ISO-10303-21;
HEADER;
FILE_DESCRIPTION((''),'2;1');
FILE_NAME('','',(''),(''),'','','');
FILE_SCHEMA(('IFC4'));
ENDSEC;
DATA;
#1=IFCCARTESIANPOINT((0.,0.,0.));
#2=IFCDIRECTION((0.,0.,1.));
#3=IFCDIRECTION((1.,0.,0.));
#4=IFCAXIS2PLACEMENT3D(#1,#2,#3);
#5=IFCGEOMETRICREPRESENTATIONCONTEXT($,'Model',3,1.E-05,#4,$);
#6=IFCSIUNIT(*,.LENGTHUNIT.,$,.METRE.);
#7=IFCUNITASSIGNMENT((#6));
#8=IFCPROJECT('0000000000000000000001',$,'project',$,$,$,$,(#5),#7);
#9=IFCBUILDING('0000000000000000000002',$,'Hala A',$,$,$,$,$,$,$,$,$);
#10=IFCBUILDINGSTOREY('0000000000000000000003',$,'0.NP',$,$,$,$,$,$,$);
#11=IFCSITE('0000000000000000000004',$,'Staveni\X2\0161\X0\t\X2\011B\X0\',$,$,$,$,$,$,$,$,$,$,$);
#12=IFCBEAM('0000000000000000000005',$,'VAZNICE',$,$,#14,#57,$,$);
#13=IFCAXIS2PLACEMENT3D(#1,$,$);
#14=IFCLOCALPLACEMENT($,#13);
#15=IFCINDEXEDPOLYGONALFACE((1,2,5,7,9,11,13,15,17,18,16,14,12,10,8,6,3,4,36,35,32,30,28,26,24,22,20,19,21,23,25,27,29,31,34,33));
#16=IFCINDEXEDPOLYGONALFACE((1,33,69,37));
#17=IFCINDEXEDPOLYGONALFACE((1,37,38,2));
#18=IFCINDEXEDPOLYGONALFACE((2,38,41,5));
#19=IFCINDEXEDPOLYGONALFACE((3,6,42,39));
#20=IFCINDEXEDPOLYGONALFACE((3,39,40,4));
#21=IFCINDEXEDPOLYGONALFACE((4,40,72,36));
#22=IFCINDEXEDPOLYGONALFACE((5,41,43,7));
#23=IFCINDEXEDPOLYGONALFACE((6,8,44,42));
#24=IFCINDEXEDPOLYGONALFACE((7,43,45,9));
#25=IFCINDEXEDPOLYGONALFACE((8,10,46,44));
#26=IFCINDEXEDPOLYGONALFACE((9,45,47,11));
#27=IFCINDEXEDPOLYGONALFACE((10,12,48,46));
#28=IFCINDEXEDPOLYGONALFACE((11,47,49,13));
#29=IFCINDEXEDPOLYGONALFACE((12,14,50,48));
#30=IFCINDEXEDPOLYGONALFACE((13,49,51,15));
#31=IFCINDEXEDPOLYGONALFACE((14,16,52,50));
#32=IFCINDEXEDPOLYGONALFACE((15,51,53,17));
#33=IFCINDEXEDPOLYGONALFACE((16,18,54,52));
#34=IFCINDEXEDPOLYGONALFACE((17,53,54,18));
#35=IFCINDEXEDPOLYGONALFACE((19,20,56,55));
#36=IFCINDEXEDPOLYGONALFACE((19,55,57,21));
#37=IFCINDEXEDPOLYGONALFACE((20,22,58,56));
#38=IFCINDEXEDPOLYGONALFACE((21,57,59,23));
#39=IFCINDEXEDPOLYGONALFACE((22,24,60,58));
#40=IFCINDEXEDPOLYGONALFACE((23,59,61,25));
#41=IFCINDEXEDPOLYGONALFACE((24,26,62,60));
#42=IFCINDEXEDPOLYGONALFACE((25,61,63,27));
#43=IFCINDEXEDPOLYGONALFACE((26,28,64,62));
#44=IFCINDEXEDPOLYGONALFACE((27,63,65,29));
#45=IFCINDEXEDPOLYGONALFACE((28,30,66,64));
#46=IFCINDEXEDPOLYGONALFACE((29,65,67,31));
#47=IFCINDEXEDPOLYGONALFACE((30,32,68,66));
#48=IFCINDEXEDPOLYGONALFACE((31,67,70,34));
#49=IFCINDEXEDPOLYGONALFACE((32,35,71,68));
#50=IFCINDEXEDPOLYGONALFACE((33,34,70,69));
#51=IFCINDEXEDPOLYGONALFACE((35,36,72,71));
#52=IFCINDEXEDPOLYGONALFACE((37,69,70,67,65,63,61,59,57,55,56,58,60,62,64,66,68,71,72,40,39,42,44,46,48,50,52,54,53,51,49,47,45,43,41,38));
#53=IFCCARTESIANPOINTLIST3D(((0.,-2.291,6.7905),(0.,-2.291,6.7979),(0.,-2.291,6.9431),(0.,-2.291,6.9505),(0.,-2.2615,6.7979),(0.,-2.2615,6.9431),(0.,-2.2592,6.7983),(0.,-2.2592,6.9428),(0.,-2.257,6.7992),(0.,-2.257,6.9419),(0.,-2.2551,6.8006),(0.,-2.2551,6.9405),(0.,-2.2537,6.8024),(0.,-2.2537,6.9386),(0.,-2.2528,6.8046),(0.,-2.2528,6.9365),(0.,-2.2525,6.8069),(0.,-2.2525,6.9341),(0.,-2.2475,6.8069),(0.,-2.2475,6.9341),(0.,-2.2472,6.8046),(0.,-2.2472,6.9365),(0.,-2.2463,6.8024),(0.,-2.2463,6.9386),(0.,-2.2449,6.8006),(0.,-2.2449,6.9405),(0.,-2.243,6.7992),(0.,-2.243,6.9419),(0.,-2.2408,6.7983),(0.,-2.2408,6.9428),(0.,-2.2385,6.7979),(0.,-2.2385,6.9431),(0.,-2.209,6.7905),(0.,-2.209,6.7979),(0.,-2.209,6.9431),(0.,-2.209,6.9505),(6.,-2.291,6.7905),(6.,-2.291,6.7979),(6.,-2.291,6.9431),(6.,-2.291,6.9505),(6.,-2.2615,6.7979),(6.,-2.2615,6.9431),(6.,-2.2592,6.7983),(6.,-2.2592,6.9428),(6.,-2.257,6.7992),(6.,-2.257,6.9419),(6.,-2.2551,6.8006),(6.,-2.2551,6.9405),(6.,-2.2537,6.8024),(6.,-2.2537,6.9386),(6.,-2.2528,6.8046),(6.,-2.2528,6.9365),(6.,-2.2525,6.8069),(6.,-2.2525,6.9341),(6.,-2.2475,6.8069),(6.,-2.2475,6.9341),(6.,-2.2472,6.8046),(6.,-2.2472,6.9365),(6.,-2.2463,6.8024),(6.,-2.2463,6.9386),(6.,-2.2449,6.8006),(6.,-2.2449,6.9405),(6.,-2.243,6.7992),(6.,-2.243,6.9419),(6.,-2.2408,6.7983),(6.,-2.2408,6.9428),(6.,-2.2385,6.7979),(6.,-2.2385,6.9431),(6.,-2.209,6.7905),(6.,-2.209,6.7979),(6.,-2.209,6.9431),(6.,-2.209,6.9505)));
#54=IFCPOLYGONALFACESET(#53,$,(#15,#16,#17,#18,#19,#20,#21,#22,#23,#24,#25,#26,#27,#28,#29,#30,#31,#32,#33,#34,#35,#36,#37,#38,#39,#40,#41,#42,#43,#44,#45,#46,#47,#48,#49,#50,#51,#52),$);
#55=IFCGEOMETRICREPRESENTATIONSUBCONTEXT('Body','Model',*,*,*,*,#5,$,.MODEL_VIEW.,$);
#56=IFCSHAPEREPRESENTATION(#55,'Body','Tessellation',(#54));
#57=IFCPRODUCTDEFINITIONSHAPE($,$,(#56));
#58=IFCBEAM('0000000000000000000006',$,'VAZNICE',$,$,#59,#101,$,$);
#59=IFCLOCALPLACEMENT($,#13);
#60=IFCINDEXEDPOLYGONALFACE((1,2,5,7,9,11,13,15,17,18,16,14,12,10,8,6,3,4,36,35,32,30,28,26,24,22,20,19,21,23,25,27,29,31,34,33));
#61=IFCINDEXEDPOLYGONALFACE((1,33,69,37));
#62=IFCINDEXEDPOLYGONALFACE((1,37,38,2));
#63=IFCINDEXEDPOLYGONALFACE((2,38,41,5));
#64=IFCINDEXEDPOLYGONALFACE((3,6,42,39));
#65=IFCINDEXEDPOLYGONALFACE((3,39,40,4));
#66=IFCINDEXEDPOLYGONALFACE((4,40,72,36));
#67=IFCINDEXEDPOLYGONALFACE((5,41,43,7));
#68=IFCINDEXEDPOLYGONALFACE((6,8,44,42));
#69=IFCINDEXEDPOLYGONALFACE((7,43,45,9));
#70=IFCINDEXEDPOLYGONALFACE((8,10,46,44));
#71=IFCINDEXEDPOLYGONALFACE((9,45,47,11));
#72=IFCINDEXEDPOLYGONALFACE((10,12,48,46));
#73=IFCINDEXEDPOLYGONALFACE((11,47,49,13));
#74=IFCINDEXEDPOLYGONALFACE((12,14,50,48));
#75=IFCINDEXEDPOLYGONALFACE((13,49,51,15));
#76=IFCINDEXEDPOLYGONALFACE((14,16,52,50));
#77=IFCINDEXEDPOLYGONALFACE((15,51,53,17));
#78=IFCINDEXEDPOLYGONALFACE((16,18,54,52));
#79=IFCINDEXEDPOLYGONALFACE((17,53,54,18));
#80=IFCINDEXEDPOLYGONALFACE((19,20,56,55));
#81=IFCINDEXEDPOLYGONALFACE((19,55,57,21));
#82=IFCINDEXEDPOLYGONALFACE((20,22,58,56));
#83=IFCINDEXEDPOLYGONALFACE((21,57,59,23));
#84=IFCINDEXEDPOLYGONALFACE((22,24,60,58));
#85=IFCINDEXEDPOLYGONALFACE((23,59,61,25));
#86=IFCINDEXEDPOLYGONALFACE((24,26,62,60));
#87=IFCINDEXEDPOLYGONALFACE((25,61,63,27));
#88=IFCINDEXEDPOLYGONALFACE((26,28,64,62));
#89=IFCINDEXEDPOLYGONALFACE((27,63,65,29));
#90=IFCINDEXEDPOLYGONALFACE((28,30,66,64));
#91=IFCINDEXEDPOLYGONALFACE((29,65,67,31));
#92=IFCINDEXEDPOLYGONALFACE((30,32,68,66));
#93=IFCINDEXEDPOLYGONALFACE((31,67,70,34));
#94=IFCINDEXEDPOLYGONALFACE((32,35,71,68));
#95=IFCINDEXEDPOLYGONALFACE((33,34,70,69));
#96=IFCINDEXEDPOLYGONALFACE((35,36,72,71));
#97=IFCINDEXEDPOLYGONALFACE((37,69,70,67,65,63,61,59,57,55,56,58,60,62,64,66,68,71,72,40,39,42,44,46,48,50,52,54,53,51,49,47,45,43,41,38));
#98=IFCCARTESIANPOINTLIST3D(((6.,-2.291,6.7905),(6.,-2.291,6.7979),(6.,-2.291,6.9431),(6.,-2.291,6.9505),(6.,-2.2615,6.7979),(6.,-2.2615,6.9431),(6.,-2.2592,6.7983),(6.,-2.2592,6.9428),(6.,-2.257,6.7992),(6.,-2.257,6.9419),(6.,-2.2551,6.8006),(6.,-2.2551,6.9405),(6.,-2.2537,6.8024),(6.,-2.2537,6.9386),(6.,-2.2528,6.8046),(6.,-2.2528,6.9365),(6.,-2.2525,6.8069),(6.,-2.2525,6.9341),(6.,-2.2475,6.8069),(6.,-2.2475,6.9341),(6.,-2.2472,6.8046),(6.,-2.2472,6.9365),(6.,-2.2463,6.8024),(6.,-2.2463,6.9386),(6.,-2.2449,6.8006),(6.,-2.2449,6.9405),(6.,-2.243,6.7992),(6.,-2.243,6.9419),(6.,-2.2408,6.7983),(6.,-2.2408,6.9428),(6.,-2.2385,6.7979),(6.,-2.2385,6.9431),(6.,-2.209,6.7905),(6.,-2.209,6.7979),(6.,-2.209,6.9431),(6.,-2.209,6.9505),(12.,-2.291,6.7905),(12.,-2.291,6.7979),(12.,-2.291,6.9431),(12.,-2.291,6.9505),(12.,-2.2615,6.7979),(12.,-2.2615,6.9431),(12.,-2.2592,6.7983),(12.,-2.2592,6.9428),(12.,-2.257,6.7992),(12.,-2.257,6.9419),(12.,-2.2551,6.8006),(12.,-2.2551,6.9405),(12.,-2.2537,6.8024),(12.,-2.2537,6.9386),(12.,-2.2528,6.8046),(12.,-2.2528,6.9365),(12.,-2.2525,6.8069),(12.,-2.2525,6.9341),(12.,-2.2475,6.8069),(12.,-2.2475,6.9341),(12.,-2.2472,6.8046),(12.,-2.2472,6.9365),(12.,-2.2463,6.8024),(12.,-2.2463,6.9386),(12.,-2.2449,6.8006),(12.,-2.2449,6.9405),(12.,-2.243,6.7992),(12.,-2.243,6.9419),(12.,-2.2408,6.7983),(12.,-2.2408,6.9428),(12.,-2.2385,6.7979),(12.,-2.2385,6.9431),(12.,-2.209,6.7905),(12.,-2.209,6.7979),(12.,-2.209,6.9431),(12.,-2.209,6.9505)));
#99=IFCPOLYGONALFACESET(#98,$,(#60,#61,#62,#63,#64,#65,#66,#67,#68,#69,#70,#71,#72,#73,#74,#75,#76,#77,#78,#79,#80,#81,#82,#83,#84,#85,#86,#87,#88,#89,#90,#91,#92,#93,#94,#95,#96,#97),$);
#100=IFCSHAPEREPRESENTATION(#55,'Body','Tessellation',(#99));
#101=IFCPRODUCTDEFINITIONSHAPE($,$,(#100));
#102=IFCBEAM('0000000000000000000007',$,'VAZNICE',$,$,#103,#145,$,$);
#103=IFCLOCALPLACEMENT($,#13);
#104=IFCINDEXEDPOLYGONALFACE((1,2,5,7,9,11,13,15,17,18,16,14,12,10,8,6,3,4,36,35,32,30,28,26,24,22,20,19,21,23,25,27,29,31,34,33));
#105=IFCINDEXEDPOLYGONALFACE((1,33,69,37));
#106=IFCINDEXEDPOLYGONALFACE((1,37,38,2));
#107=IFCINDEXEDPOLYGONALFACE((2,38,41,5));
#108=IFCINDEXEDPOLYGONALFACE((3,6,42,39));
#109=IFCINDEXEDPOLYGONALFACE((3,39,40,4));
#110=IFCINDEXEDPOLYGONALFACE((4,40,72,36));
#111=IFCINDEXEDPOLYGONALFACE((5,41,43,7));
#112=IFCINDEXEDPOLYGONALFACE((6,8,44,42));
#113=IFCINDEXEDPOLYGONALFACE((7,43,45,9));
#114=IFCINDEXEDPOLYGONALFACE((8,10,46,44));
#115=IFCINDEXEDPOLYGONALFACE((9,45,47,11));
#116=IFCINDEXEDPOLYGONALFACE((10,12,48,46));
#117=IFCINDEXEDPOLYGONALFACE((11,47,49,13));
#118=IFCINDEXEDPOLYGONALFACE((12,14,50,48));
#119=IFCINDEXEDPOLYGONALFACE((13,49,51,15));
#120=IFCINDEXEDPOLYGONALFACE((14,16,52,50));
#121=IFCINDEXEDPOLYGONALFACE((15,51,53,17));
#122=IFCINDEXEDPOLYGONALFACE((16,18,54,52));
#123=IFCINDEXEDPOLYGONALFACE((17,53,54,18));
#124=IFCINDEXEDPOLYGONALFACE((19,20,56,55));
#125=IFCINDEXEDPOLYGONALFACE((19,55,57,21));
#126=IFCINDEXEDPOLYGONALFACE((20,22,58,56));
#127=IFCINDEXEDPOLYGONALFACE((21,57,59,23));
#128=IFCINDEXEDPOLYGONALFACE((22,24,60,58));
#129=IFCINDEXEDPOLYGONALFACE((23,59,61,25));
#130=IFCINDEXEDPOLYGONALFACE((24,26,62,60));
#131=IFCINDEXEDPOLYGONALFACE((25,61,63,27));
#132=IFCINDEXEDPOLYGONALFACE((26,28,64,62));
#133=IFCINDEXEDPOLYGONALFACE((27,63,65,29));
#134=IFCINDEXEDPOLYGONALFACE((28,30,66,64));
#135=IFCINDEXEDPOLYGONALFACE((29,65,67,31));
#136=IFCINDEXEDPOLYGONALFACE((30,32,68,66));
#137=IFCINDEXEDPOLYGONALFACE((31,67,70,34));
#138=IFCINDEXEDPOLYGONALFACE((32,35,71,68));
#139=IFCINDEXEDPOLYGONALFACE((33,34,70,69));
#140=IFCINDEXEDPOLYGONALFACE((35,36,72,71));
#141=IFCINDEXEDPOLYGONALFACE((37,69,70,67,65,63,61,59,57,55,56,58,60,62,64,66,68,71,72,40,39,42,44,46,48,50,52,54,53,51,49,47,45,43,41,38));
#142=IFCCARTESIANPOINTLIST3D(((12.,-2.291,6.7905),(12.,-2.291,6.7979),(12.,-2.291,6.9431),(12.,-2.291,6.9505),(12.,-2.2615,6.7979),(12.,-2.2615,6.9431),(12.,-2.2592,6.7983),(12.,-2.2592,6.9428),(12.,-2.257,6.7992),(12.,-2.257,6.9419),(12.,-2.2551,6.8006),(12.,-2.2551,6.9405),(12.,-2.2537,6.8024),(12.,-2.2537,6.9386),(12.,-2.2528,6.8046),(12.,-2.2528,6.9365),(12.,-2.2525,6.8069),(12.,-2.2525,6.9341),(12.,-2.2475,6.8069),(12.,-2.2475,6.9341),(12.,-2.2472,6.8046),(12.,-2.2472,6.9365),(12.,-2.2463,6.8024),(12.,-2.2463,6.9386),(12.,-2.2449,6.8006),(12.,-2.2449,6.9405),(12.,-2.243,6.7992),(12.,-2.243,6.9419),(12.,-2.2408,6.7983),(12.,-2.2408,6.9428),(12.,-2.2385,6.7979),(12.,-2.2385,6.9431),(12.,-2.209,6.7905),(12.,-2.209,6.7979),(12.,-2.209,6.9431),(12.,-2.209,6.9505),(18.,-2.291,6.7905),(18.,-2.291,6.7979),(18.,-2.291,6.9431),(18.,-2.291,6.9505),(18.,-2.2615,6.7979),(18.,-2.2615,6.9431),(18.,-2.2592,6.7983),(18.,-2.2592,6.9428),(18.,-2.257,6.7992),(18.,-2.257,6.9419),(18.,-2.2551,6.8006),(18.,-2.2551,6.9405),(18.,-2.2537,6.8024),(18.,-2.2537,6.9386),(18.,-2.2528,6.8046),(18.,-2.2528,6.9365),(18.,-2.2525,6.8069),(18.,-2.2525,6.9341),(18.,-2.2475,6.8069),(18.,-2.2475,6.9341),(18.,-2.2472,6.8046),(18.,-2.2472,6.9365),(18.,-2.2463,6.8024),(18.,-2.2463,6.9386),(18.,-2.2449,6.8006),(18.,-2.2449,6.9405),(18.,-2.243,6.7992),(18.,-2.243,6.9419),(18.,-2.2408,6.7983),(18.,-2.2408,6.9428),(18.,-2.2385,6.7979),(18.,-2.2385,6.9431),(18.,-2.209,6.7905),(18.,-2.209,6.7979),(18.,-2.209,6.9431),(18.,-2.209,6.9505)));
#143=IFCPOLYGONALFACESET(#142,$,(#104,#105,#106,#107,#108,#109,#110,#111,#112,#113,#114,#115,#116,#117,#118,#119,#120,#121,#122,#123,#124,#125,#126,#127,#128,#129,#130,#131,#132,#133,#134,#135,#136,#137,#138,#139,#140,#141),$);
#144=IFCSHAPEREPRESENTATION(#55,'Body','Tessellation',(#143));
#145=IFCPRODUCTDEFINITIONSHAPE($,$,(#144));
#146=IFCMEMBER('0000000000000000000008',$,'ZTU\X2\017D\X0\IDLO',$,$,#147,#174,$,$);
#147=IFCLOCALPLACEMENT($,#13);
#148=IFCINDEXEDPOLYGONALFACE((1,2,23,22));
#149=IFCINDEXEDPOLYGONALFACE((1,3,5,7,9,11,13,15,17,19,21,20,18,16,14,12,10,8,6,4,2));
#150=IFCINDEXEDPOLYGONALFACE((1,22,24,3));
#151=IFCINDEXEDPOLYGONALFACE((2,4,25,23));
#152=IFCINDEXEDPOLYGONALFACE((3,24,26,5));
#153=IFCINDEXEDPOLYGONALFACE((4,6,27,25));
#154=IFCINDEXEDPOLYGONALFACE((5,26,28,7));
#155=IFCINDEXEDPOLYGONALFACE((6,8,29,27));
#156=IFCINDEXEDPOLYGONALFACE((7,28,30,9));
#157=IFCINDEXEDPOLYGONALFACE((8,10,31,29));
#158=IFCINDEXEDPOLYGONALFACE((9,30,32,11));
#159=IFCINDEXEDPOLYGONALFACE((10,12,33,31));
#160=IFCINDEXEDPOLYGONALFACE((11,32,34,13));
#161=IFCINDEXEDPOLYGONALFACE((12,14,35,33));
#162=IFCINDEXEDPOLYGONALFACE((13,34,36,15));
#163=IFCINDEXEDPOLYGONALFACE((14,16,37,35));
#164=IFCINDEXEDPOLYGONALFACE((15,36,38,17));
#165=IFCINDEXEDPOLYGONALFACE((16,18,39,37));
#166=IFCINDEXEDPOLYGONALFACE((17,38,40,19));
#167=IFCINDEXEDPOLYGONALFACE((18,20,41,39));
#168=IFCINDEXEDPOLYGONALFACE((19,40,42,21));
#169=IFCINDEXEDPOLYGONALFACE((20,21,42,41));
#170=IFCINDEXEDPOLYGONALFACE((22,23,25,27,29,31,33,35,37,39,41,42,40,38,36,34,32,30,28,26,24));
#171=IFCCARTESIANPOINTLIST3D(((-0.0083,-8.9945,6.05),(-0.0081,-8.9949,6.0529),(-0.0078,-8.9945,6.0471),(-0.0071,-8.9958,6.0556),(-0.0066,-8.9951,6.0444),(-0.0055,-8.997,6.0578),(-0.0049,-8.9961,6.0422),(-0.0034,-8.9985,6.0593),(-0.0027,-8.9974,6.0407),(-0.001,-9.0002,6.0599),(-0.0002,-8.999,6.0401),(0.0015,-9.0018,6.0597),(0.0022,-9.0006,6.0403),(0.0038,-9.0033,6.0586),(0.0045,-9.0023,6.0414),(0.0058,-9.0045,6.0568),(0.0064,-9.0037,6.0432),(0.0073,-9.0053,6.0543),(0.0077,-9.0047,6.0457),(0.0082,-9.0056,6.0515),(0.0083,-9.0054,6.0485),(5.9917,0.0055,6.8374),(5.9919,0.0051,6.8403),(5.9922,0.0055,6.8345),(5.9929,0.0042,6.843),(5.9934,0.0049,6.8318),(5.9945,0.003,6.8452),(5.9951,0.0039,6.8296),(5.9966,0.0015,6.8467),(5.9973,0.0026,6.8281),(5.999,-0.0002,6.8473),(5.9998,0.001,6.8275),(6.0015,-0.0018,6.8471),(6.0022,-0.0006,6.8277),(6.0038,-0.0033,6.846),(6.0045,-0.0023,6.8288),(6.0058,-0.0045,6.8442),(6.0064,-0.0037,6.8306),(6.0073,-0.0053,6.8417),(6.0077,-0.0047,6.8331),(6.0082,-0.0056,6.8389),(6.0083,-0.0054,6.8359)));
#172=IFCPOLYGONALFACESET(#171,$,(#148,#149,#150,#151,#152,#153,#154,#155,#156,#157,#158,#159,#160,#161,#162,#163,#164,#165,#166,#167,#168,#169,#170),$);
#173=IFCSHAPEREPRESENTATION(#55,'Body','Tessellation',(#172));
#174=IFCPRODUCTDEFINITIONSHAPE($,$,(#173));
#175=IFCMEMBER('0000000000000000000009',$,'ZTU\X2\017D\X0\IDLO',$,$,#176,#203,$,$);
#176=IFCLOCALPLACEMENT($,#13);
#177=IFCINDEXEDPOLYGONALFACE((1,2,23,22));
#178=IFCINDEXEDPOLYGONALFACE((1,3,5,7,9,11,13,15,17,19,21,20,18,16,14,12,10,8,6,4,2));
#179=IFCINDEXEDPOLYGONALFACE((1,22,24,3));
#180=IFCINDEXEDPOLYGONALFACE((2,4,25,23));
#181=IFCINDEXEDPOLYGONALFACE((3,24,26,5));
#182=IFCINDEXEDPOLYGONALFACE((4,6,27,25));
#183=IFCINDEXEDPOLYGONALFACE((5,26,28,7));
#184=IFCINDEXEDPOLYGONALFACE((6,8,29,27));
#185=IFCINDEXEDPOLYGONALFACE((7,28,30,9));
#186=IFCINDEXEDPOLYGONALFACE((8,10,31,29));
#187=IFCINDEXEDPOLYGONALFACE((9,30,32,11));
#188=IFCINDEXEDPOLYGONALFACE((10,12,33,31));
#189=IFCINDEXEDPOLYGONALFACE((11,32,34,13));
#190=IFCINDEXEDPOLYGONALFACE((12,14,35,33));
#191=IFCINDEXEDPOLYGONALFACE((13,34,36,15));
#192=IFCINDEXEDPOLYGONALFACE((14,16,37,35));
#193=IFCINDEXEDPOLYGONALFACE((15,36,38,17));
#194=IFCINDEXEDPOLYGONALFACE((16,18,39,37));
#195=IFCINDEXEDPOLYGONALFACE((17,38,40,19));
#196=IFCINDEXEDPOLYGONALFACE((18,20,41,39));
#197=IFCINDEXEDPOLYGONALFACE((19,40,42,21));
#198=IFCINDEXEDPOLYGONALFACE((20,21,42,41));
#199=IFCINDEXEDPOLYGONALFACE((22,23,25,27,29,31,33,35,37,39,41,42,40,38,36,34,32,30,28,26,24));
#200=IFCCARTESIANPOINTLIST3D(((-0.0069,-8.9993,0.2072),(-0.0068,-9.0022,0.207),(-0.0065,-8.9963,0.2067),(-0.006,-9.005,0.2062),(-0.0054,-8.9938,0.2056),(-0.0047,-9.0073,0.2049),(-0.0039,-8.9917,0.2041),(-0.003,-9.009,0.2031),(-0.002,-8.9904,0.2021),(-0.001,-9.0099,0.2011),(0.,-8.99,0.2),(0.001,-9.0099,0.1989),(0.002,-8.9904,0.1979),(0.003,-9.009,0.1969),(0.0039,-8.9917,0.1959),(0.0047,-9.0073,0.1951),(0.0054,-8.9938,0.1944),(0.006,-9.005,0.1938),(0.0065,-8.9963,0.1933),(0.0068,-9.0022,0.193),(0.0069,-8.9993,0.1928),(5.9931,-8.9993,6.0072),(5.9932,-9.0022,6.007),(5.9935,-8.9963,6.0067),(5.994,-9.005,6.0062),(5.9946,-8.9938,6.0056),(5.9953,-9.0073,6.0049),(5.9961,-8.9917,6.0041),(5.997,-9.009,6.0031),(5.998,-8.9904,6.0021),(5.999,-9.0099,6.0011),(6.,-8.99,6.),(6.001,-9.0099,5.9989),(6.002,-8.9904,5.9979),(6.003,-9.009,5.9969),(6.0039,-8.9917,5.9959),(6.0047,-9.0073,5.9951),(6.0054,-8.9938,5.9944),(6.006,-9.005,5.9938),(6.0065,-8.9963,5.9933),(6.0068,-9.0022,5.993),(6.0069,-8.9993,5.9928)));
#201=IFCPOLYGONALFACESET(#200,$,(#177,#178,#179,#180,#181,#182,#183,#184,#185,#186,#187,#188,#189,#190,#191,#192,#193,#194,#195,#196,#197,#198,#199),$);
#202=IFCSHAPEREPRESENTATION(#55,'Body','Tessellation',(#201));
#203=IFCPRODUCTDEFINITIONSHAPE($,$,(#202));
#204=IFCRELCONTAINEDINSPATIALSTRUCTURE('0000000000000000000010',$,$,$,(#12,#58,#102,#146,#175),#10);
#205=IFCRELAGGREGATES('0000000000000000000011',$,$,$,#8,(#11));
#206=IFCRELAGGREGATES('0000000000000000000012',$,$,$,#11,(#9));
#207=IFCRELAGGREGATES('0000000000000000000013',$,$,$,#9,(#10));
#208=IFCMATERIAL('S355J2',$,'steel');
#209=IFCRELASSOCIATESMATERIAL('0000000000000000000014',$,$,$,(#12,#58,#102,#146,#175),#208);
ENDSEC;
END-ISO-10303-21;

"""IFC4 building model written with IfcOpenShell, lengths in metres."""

from ifc_helpers import new_model, si_unit, frame, origin_with_axes, place, context, subcontext, project, spatial, circle, i_section, extrude, material, element, save


model = new_model("IFC4")

# Units and contexts
model_context = context("Model", 3, precision=1e-05, world=origin_with_axes())
body_context = subcontext(model_context, "Body", "Model", "MODEL_VIEW")
ifc_project = project(units=[si_unit("LENGTHUNIT", "METRE")], contexts=[model_context])

# Site, building, storey
site = spatial("IfcSite", under=ifc_project, Name="Staveniště")
building = spatial("IfcBuilding", under=site, Name="Hala A")
storey = spatial("IfcBuildingStorey", under=building, Name="0.NP")

# Shared definitions
ifc_material = material(Name="S355J2", Category="steel")

# Beams
for number, where, z_axis, x_axis, name in (
    (1, (0.0, -2.25, 6.8705), (1.0, 0.0, 0.0), (0.0, 1.0, 0.0), "VAZNICE"),
    (2, (6.0, -2.25, 6.8705), (1.0, 0.0, 0.0), (0.0, 1.0, 0.0), "VAZNICE"),
    (3, (12.0, -2.25, 6.8705), (1.0, 0.0, 0.0), (0.0, 1.0, 0.0), "VAZNICE"),
):
    element("IfcBeam", number, at=place(None, frame(where, z_axis=z_axis, x_axis=x_axis)), inside=storey, material=ifc_material, Name=name, context=body_context, shape_type="SweptSolid", body=[
        extrude(i_section(OverallWidth=0.082, OverallDepth=0.16, WebThickness=0.005, FlangeThickness=0.0074, FilletRadius=0.009), origin_with_axes(), (0.0, 0.0, 1.0), 6.0),
    ])

# Members
member_placement = place(None, frame((0.0, -9.0, 6.05), z_axis=(0.553236, 0.829854, 0.072603), x_axis=(-0.83205, 0.5547, 0.0)))
element("IfcMember", 4, at=member_placement, inside=storey, material=ifc_material, Name="ZTUŽIDLO", context=body_context, shape_type="SweptSolid", body=[
    extrude(circle(Radius=0.01), origin_with_axes(), (0.0, 0.0, 1.0), 10.8453),
])
for number, where, z_axis, x_axis, name in (
    (5, (0.0, -9.0, 0.2), (0.718988, 0.0, 0.695022), (0.0, 1.0, 0.0), "ZTUŽIDLO"),
):
    element("IfcMember", number, at=place(None, frame(where, z_axis=z_axis, x_axis=x_axis)), inside=storey, material=ifc_material, Name=name, context=body_context, shape_type="SweptSolid", body=[
        extrude(circle(Radius=0.01), origin_with_axes(), (0.0, 0.0, 1.0), 8.3451),
    ])

save(model, "model.ifc")
